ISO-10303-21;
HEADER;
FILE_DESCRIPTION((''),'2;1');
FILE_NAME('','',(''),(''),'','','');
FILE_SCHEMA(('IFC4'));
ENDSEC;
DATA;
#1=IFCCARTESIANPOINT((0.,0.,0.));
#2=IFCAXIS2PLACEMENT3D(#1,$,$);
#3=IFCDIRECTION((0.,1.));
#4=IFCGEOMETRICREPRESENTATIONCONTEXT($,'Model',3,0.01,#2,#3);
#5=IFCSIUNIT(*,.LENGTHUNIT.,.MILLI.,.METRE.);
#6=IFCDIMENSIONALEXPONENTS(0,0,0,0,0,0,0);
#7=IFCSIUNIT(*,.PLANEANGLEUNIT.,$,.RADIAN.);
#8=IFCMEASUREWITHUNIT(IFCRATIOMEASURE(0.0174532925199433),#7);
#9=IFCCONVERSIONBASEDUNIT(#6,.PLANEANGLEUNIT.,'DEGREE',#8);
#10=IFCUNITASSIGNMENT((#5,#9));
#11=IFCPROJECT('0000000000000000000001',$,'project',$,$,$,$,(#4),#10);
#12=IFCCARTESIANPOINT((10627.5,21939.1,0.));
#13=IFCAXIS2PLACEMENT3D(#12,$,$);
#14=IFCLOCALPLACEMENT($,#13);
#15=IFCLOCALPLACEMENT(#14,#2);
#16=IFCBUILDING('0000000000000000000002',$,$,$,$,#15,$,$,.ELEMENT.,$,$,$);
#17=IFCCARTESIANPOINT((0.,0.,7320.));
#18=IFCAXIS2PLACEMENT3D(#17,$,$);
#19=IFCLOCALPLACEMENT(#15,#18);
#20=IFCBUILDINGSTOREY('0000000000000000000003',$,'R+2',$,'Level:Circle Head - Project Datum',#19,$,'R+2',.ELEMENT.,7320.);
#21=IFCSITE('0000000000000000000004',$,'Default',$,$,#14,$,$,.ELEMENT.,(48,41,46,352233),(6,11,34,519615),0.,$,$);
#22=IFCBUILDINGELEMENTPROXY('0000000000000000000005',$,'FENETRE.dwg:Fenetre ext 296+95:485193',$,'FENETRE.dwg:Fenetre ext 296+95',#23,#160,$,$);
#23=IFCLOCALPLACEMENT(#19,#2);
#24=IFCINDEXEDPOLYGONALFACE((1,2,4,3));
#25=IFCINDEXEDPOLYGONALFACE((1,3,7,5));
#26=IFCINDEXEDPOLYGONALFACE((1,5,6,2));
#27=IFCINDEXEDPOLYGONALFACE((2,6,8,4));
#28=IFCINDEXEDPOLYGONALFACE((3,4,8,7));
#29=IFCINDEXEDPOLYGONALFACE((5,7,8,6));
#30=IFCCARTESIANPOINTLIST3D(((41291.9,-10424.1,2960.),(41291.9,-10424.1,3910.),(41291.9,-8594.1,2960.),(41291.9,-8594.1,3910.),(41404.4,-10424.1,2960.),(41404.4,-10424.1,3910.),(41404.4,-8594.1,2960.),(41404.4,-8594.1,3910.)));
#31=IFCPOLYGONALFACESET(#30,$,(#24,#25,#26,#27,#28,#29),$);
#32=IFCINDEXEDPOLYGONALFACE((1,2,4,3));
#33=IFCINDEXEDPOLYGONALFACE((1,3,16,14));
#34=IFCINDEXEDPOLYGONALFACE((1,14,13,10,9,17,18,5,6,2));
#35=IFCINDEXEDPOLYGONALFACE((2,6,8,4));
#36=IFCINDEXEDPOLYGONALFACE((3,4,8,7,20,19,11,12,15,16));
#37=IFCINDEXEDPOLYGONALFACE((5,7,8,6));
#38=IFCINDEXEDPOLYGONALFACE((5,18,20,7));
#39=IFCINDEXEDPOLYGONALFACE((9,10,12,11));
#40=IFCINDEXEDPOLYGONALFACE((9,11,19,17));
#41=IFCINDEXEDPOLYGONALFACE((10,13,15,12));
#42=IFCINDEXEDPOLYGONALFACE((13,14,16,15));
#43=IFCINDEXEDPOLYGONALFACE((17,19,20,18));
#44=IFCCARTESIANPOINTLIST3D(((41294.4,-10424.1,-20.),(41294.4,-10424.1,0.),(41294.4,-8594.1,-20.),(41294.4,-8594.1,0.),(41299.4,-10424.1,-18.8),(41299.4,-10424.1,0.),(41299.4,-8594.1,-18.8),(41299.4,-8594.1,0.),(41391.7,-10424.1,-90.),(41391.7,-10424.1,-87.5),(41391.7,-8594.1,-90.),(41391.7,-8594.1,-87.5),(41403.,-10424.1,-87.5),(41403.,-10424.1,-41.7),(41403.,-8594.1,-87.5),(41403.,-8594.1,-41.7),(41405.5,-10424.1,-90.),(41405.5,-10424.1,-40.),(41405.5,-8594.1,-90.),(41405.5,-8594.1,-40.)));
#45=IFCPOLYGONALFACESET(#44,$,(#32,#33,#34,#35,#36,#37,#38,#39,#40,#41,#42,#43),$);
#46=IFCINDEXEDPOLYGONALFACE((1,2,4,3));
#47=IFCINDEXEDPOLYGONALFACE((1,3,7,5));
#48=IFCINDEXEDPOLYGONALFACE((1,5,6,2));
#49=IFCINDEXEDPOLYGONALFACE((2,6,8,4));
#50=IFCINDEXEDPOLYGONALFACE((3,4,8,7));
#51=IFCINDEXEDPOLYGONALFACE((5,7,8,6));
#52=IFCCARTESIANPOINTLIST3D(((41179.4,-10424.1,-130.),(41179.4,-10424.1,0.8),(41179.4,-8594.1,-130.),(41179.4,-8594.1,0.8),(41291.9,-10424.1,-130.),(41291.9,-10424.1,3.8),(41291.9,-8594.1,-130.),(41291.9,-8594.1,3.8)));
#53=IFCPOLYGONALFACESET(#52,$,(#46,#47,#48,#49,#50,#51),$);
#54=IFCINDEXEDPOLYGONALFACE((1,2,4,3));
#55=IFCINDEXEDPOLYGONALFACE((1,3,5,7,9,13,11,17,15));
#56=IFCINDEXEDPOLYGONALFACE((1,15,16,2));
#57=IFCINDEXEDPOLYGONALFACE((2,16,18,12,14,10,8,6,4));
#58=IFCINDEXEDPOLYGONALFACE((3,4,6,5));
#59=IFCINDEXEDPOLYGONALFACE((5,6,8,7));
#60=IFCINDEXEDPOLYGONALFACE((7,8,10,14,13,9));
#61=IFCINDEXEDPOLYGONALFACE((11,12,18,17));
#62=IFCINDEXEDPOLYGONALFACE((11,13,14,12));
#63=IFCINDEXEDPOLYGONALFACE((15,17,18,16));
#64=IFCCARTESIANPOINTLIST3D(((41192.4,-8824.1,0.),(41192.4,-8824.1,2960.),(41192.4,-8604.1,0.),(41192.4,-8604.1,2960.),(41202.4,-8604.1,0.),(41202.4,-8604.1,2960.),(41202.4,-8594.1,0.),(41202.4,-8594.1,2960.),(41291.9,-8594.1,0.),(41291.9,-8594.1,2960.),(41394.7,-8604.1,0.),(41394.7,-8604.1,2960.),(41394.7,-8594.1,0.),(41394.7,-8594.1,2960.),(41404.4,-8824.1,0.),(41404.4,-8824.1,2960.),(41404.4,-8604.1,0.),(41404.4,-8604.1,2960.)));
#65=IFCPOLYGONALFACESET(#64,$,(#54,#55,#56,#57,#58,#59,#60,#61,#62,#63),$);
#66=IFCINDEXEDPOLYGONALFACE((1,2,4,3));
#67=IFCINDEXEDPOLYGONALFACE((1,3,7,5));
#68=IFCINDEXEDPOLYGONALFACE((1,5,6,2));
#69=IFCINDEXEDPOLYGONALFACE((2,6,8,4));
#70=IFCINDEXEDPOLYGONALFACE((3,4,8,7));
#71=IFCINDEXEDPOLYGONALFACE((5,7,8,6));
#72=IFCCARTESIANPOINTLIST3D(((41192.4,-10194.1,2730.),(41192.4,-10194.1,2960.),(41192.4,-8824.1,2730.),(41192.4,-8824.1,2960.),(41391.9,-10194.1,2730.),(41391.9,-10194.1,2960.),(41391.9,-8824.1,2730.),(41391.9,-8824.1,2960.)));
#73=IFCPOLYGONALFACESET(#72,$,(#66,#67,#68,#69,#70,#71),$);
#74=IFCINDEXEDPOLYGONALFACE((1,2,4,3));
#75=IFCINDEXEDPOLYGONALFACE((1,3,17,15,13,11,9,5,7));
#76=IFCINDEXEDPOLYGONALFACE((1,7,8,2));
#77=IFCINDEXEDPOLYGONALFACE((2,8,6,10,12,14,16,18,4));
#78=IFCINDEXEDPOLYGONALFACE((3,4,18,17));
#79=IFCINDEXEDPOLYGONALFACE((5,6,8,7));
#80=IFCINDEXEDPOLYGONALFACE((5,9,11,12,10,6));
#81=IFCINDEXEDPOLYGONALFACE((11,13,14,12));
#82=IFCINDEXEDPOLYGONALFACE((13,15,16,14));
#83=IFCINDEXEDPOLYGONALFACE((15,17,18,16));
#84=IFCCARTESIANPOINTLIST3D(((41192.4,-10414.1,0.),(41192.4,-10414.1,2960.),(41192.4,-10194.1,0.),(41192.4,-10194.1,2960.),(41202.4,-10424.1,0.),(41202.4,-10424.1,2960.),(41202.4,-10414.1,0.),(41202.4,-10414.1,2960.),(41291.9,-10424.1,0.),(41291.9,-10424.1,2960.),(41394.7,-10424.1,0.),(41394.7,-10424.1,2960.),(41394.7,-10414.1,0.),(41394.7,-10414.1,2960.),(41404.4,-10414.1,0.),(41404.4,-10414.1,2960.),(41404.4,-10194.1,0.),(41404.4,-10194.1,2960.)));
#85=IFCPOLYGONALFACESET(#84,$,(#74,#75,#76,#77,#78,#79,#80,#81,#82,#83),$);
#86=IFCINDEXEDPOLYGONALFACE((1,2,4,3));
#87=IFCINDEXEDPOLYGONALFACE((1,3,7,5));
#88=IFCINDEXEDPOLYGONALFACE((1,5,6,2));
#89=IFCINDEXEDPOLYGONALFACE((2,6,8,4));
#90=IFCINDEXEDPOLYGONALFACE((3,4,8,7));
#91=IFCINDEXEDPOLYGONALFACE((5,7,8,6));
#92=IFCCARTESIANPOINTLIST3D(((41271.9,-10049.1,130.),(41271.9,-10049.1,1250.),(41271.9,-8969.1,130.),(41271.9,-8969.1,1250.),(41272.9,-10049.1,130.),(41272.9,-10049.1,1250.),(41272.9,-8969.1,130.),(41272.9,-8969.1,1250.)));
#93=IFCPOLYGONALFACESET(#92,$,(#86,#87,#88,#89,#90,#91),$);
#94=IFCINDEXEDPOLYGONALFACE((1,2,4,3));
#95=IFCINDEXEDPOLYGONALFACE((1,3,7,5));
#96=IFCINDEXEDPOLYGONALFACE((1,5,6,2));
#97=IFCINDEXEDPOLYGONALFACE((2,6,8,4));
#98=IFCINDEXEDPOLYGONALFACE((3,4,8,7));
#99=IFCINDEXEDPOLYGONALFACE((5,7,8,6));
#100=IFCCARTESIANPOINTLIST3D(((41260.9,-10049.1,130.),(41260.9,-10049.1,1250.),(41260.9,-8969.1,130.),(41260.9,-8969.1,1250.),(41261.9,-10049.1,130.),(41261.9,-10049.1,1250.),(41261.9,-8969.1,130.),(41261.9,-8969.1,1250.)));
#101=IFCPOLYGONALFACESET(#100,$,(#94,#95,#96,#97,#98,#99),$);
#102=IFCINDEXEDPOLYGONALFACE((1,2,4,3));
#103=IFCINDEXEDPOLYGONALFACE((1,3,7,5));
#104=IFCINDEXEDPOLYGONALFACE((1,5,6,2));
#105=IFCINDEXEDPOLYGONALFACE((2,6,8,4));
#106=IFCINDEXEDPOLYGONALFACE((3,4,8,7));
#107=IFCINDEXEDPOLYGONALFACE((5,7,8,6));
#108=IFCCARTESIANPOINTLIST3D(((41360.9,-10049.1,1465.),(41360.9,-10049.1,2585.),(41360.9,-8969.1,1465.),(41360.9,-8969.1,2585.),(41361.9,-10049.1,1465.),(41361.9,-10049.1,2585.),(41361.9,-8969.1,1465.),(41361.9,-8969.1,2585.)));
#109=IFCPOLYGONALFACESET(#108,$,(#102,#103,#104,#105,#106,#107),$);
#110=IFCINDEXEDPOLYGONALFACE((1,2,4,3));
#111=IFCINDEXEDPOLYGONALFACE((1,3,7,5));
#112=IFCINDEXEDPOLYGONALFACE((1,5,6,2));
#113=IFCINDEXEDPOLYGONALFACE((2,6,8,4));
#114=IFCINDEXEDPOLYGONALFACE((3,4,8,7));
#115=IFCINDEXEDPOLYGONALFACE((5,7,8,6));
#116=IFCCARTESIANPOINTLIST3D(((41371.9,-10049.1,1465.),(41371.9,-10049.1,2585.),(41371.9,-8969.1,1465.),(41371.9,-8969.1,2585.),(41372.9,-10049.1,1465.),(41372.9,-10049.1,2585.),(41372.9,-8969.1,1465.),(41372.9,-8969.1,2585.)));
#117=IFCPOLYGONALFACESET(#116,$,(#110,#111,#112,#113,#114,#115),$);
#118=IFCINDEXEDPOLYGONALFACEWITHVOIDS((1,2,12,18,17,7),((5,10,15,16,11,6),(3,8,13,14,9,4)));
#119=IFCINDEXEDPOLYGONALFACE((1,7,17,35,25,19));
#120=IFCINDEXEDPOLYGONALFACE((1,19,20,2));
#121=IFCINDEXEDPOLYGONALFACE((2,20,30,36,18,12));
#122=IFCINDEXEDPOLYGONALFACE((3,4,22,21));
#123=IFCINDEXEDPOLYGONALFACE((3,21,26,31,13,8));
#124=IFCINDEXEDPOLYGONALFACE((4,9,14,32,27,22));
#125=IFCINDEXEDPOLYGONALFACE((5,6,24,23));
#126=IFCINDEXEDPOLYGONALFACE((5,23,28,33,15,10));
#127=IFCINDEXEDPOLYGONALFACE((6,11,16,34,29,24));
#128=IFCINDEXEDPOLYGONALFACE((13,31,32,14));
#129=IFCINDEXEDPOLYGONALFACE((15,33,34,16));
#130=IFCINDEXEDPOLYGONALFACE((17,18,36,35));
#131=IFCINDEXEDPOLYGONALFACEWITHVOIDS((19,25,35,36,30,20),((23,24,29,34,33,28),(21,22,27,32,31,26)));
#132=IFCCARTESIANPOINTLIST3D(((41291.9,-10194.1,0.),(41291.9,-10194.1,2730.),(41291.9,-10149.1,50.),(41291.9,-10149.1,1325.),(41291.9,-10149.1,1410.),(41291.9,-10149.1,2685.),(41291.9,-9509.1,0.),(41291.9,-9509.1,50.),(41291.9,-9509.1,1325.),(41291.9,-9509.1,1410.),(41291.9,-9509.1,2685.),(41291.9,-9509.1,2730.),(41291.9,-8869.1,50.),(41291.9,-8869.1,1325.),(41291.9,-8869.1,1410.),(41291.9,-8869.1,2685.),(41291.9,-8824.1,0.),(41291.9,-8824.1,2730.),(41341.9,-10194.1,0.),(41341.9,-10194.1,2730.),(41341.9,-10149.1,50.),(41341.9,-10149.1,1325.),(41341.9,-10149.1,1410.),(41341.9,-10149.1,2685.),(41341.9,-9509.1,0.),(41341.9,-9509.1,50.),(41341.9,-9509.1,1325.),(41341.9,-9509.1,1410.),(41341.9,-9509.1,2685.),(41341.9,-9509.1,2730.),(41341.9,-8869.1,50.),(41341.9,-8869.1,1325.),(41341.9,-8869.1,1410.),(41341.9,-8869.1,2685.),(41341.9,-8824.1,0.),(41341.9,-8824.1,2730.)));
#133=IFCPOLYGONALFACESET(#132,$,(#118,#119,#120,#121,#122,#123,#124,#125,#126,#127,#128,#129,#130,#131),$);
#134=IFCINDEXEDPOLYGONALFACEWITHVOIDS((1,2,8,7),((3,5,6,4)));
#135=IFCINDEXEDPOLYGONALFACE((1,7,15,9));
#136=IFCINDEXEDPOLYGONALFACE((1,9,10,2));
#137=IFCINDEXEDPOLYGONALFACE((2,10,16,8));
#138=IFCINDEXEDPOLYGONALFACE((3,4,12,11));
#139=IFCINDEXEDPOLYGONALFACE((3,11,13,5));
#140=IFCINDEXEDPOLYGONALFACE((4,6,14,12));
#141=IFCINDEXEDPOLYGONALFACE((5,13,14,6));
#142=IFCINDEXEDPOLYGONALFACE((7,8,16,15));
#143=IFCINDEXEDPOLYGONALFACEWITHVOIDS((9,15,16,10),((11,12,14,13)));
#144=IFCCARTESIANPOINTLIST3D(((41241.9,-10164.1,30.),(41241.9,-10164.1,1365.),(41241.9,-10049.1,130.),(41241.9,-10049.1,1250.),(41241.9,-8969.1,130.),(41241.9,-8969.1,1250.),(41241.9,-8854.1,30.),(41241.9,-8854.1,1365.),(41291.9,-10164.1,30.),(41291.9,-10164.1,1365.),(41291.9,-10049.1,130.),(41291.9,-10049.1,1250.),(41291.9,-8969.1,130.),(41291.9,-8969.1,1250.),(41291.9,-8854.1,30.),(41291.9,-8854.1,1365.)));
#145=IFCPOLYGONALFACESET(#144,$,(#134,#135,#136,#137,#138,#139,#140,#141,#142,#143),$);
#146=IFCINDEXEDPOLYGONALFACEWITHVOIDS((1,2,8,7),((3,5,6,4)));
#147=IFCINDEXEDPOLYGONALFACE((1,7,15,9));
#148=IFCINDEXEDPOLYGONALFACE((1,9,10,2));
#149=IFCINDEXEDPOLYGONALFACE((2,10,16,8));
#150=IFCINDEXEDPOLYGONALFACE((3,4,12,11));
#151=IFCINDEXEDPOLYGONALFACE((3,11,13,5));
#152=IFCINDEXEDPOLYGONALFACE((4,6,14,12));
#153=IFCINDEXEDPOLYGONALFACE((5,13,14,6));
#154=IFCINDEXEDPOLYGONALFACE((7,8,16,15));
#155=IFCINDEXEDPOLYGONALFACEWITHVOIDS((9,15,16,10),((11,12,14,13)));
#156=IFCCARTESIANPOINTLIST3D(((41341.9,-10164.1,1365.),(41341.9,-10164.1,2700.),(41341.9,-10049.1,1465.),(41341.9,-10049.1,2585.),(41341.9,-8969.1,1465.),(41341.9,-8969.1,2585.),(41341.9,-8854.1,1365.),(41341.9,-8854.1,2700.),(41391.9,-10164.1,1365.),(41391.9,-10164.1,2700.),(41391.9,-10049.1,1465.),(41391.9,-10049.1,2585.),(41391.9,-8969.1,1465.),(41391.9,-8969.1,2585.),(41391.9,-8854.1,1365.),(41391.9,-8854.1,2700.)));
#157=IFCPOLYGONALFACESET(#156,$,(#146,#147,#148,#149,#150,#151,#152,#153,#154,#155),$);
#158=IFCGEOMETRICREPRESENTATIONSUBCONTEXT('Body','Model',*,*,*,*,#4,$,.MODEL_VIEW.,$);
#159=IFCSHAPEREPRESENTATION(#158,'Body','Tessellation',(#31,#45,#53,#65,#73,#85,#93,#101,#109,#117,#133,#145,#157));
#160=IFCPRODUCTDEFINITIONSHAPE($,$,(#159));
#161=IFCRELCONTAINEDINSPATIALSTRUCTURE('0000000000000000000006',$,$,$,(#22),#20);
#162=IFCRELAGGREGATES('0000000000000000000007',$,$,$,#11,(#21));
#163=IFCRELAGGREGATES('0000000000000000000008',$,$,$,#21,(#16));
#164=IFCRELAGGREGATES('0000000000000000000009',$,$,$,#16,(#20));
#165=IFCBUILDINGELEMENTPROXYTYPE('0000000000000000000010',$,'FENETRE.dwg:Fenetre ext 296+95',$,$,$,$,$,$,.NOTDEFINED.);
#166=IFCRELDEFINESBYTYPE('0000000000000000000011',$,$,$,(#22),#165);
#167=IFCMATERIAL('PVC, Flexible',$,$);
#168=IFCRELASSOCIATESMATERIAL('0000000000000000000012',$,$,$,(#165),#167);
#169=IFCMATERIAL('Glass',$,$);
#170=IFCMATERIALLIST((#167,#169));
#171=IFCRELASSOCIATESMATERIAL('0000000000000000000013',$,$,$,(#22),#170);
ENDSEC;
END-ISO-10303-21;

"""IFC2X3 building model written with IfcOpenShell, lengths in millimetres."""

from ifc_helpers import new_model, entity, si_unit, converted_unit, direction, frame, frame_2d, origin, origin_2d_with_axis, place, context, subcontext, project, spatial, polyline, rectangle, outline, extrude, source, transform, mapped, material, material_list, type_object, type_shapes, element, save


model = new_model("IFC2X3")

# Units and contexts
model_context = context("Model", 3, precision=0.01, world=origin(), true_north=direction((0.0, 1.0)))
body_context = subcontext(model_context, "Body", "Model", "MODEL_VIEW")
ifc_project = project(units=[si_unit("LENGTHUNIT", "METRE", prefix="MILLI"), converted_unit("PLANEANGLEUNIT", "DEGREE", entity("IfcRatioMeasure", 0.0174532925199433), si_unit("PLANEANGLEUNIT", "RADIAN"), dimensions=[0, 0, 0, 0, 0, 0, 0])], contexts=[model_context])

# Site, building, storey
site_placement = place(None, frame((10627.5, 21939.1, 0.0)))
site = spatial("IfcSite", under=ifc_project, at=site_placement, Name="Default", CompositionType="ELEMENT", RefLatitude=(48, 41, 46, 352233), RefLongitude=(6, 11, 34, 519615), RefElevation=0.0)
building_placement = place(site_placement, origin())
building = spatial("IfcBuilding", under=site, at=building_placement, CompositionType="ELEMENT")
storey_placement = place(building_placement, frame((0.0, 0.0, 7320.0)))
storey = spatial("IfcBuildingStorey", under=building, at=storey_placement, Name="R+2", ObjectType="Level:Circle Head - Project Datum", LongName="R+2", CompositionType="ELEMENT", Elevation=7320.0)

# Building element proxy
ifc_material_1 = material(Name="PVC, Flexible")
ifc_material_2 = material(Name="Glass")
building_element_proxy_type_1 = type_object("IfcBuildingElementProxyType", Name="FENETRE.dwg:Fenetre ext 296+95", PredefinedType="NOTDEFINED", material=ifc_material_1)
shared_shape_1 = source(origin(), body_context, "Body", "SweptSolid", [
    extrude(rectangle(XDim=112.5, YDim=1830.0, at=origin_2d_with_axis()), frame((-10.4, -56.3, 2960.0), z_axis=(0.0, 0.0, 1.0), x_axis=(0.0, 1.0, 0.0)), (0.0, 0.0, 1.0), 950.0),
    extrude(outline(polyline([(27.5, -64.4), (47.5, -64.4), (47.5, -59.4), (28.8, -59.4), (7.5, 46.7), (-42.5, 46.7), (-42.5, 32.9), (-40.0, 32.9), (-40.0, 44.2), (5.8, 44.2), (27.5, -64.4)])), frame((-925.4, -66.9, -47.5), z_axis=(1.0, 0.0, 0.0), x_axis=(0.0, 0.0, 1.0)), (0.0, 0.0, 1.0), 1830.0),
    extrude(outline(polyline([(-54.5, -66.1), (58.0, -66.1), (54.5, 67.6), (-58.0, 64.6), (-54.5, -66.1)])), frame((-925.4, 56.3, -63.8), z_axis=(1.0, 0.0, 0.0), x_axis=(0.0, -0.999645, 0.02665)), (0.0, 0.0, 1.0), 1830.0),
    extrude(outline(polyline([(-97.0, -55.6), (5.9, -55.6), (95.4, -55.6), (95.4, -45.6), (105.4, -45.6), (105.4, 174.4), (-106.6, 174.4), (-106.6, -45.6), (-97.0, -45.6), (-97.0, -55.6)])), frame((849.0, -5.9, 0.0), z_axis=(0.0, 0.0, 1.0), x_axis=(0.0, 1.0, 0.0)), (0.0, 0.0, 1.0), 2960.0),
    extrude(rectangle(XDim=1370.0, YDim=199.5, at=origin_2d_with_axis()), frame((-10.4, -0.3, 2730.0), z_axis=(0.0, 0.0, 1.0), x_axis=(-1.0, 0.0, 0.0)), (0.0, 0.0, 1.0), 230.0),
    extrude(outline(polyline([(-55.6, 97.0), (-55.6, -5.9), (-55.6, -95.4), (-45.6, -95.4), (-45.6, -105.4), (174.4, -105.4), (174.4, 106.6), (-45.6, 106.6), (-45.6, 97.0), (-55.6, 97.0)])), frame((-869.9, -5.9, 0.0), z_axis=(0.0, 0.0, -1.0), x_axis=(1.0, 0.0, 0.0)), (0.0, 0.0, -1.0), 2960.0),
    extrude(rectangle(XDim=1080.0, YDim=1.0, at=origin_2d_with_axis()), frame((-10.4, 19.5, 130.0), z_axis=(0.0, 0.0, 1.0), x_axis=(-1.0, 0.0, 0.0)), (0.0, 0.0, 1.0), 1120.0),
    extrude(rectangle(XDim=1080.0, YDim=1.0, at=origin_2d_with_axis()), frame((-10.4, 30.5, 130.0), z_axis=(0.0, 0.0, 1.0), x_axis=(-1.0, 0.0, 0.0)), (0.0, 0.0, 1.0), 1120.0),
    extrude(rectangle(XDim=1080.0, YDim=1.0, at=frame_2d((0.0, 0.0), x_axis=(1.0, 0.0))), frame((-10.4, -69.5, 1465.0), z_axis=(0.0, 0.0, 1.0), x_axis=(-1.0, 0.0, 0.0)), (0.0, 0.0, 1.0), 1120.0),
    extrude(rectangle(XDim=1080.0, YDim=1.0, at=frame_2d((0.0, 0.0), x_axis=(1.0, 0.0))), frame((-10.4, -80.5, 1465.0), z_axis=(0.0, 0.0, 1.0), x_axis=(-1.0, 0.0, 0.0)), (0.0, 0.0, 1.0), 1120.0),
    extrude(outline(polyline([(-685.0, -1365.0), (0.0, -1365.0), (685.0, -1365.0), (685.0, 1365.0), (0.0, 1365.0), (-685.0, 1365.0), (-685.0, -1365.0)]), holes=[polyline([(-640.0, -1320.0), (-640.0, -45.0), (0.0, -45.0), (640.0, -45.0), (640.0, -1320.0), (0.0, -1320.0), (-640.0, -1320.0)]), polyline([(-640.0, 40.0), (-640.0, 1315.0), (0.0, 1315.0), (640.0, 1315.0), (640.0, 40.0), (0.0, 40.0), (-640.0, 40.0)])]), frame((-10.4, -50.0, 1365.0), z_axis=(0.0, 1.0, 0.0), x_axis=(1.0, 0.0, 0.0)), (0.0, 0.0, 1.0), 50.0),
    extrude(outline(polyline([(-655.0, -667.5), (655.0, -667.5), (655.0, 667.5), (-655.0, 667.5), (-655.0, -667.5)]), holes=[polyline([(-540.0, 552.5), (540.0, 552.5), (540.0, -567.5), (-540.0, -567.5), (-540.0, 552.5)])]), frame((-10.4, 0.0, 697.5), z_axis=(0.0, 1.0, 0.0), x_axis=(-1.0, 0.0, 0.0)), (0.0, 0.0, 1.0), 50.0),
    extrude(outline(polyline([(-655.0, -667.5), (655.0, -667.5), (655.0, 667.5), (-655.0, 667.5), (-655.0, -667.5)]), holes=[polyline([(-540.0, 552.5), (540.0, 552.5), (540.0, -567.5), (-540.0, -567.5), (-540.0, 552.5)])]), frame((-10.4, -100.0, 2032.5), z_axis=(0.0, 1.0, 0.0), x_axis=(-1.0, 0.0, 0.0)), (0.0, 0.0, 1.0), 50.0),
])
type_shapes(building_element_proxy_type_1, [shared_shape_1])
ifc_material_list_1 = material_list([ifc_material_1, ifc_material_2])
proxy_1_placement = place(storey_placement, frame((41291.9, -9498.7, 0.0), z_axis=(0.0, 0.0, 1.0), x_axis=(0.0, 1.0, 0.0)))
element("IfcBuildingElementProxy", 1, at=proxy_1_placement, inside=storey, type_object=building_element_proxy_type_1, material=ifc_material_list_1, Name="FENETRE.dwg:Fenetre ext 296+95:485193", ObjectType="FENETRE.dwg:Fenetre ext 296+95", context=body_context, shape_type="MappedRepresentation", body=[
    mapped(shared_shape_1, transform((0.0, 0.0, 0.0), scale=1.0)),
])

save(model, "model.ifc")
